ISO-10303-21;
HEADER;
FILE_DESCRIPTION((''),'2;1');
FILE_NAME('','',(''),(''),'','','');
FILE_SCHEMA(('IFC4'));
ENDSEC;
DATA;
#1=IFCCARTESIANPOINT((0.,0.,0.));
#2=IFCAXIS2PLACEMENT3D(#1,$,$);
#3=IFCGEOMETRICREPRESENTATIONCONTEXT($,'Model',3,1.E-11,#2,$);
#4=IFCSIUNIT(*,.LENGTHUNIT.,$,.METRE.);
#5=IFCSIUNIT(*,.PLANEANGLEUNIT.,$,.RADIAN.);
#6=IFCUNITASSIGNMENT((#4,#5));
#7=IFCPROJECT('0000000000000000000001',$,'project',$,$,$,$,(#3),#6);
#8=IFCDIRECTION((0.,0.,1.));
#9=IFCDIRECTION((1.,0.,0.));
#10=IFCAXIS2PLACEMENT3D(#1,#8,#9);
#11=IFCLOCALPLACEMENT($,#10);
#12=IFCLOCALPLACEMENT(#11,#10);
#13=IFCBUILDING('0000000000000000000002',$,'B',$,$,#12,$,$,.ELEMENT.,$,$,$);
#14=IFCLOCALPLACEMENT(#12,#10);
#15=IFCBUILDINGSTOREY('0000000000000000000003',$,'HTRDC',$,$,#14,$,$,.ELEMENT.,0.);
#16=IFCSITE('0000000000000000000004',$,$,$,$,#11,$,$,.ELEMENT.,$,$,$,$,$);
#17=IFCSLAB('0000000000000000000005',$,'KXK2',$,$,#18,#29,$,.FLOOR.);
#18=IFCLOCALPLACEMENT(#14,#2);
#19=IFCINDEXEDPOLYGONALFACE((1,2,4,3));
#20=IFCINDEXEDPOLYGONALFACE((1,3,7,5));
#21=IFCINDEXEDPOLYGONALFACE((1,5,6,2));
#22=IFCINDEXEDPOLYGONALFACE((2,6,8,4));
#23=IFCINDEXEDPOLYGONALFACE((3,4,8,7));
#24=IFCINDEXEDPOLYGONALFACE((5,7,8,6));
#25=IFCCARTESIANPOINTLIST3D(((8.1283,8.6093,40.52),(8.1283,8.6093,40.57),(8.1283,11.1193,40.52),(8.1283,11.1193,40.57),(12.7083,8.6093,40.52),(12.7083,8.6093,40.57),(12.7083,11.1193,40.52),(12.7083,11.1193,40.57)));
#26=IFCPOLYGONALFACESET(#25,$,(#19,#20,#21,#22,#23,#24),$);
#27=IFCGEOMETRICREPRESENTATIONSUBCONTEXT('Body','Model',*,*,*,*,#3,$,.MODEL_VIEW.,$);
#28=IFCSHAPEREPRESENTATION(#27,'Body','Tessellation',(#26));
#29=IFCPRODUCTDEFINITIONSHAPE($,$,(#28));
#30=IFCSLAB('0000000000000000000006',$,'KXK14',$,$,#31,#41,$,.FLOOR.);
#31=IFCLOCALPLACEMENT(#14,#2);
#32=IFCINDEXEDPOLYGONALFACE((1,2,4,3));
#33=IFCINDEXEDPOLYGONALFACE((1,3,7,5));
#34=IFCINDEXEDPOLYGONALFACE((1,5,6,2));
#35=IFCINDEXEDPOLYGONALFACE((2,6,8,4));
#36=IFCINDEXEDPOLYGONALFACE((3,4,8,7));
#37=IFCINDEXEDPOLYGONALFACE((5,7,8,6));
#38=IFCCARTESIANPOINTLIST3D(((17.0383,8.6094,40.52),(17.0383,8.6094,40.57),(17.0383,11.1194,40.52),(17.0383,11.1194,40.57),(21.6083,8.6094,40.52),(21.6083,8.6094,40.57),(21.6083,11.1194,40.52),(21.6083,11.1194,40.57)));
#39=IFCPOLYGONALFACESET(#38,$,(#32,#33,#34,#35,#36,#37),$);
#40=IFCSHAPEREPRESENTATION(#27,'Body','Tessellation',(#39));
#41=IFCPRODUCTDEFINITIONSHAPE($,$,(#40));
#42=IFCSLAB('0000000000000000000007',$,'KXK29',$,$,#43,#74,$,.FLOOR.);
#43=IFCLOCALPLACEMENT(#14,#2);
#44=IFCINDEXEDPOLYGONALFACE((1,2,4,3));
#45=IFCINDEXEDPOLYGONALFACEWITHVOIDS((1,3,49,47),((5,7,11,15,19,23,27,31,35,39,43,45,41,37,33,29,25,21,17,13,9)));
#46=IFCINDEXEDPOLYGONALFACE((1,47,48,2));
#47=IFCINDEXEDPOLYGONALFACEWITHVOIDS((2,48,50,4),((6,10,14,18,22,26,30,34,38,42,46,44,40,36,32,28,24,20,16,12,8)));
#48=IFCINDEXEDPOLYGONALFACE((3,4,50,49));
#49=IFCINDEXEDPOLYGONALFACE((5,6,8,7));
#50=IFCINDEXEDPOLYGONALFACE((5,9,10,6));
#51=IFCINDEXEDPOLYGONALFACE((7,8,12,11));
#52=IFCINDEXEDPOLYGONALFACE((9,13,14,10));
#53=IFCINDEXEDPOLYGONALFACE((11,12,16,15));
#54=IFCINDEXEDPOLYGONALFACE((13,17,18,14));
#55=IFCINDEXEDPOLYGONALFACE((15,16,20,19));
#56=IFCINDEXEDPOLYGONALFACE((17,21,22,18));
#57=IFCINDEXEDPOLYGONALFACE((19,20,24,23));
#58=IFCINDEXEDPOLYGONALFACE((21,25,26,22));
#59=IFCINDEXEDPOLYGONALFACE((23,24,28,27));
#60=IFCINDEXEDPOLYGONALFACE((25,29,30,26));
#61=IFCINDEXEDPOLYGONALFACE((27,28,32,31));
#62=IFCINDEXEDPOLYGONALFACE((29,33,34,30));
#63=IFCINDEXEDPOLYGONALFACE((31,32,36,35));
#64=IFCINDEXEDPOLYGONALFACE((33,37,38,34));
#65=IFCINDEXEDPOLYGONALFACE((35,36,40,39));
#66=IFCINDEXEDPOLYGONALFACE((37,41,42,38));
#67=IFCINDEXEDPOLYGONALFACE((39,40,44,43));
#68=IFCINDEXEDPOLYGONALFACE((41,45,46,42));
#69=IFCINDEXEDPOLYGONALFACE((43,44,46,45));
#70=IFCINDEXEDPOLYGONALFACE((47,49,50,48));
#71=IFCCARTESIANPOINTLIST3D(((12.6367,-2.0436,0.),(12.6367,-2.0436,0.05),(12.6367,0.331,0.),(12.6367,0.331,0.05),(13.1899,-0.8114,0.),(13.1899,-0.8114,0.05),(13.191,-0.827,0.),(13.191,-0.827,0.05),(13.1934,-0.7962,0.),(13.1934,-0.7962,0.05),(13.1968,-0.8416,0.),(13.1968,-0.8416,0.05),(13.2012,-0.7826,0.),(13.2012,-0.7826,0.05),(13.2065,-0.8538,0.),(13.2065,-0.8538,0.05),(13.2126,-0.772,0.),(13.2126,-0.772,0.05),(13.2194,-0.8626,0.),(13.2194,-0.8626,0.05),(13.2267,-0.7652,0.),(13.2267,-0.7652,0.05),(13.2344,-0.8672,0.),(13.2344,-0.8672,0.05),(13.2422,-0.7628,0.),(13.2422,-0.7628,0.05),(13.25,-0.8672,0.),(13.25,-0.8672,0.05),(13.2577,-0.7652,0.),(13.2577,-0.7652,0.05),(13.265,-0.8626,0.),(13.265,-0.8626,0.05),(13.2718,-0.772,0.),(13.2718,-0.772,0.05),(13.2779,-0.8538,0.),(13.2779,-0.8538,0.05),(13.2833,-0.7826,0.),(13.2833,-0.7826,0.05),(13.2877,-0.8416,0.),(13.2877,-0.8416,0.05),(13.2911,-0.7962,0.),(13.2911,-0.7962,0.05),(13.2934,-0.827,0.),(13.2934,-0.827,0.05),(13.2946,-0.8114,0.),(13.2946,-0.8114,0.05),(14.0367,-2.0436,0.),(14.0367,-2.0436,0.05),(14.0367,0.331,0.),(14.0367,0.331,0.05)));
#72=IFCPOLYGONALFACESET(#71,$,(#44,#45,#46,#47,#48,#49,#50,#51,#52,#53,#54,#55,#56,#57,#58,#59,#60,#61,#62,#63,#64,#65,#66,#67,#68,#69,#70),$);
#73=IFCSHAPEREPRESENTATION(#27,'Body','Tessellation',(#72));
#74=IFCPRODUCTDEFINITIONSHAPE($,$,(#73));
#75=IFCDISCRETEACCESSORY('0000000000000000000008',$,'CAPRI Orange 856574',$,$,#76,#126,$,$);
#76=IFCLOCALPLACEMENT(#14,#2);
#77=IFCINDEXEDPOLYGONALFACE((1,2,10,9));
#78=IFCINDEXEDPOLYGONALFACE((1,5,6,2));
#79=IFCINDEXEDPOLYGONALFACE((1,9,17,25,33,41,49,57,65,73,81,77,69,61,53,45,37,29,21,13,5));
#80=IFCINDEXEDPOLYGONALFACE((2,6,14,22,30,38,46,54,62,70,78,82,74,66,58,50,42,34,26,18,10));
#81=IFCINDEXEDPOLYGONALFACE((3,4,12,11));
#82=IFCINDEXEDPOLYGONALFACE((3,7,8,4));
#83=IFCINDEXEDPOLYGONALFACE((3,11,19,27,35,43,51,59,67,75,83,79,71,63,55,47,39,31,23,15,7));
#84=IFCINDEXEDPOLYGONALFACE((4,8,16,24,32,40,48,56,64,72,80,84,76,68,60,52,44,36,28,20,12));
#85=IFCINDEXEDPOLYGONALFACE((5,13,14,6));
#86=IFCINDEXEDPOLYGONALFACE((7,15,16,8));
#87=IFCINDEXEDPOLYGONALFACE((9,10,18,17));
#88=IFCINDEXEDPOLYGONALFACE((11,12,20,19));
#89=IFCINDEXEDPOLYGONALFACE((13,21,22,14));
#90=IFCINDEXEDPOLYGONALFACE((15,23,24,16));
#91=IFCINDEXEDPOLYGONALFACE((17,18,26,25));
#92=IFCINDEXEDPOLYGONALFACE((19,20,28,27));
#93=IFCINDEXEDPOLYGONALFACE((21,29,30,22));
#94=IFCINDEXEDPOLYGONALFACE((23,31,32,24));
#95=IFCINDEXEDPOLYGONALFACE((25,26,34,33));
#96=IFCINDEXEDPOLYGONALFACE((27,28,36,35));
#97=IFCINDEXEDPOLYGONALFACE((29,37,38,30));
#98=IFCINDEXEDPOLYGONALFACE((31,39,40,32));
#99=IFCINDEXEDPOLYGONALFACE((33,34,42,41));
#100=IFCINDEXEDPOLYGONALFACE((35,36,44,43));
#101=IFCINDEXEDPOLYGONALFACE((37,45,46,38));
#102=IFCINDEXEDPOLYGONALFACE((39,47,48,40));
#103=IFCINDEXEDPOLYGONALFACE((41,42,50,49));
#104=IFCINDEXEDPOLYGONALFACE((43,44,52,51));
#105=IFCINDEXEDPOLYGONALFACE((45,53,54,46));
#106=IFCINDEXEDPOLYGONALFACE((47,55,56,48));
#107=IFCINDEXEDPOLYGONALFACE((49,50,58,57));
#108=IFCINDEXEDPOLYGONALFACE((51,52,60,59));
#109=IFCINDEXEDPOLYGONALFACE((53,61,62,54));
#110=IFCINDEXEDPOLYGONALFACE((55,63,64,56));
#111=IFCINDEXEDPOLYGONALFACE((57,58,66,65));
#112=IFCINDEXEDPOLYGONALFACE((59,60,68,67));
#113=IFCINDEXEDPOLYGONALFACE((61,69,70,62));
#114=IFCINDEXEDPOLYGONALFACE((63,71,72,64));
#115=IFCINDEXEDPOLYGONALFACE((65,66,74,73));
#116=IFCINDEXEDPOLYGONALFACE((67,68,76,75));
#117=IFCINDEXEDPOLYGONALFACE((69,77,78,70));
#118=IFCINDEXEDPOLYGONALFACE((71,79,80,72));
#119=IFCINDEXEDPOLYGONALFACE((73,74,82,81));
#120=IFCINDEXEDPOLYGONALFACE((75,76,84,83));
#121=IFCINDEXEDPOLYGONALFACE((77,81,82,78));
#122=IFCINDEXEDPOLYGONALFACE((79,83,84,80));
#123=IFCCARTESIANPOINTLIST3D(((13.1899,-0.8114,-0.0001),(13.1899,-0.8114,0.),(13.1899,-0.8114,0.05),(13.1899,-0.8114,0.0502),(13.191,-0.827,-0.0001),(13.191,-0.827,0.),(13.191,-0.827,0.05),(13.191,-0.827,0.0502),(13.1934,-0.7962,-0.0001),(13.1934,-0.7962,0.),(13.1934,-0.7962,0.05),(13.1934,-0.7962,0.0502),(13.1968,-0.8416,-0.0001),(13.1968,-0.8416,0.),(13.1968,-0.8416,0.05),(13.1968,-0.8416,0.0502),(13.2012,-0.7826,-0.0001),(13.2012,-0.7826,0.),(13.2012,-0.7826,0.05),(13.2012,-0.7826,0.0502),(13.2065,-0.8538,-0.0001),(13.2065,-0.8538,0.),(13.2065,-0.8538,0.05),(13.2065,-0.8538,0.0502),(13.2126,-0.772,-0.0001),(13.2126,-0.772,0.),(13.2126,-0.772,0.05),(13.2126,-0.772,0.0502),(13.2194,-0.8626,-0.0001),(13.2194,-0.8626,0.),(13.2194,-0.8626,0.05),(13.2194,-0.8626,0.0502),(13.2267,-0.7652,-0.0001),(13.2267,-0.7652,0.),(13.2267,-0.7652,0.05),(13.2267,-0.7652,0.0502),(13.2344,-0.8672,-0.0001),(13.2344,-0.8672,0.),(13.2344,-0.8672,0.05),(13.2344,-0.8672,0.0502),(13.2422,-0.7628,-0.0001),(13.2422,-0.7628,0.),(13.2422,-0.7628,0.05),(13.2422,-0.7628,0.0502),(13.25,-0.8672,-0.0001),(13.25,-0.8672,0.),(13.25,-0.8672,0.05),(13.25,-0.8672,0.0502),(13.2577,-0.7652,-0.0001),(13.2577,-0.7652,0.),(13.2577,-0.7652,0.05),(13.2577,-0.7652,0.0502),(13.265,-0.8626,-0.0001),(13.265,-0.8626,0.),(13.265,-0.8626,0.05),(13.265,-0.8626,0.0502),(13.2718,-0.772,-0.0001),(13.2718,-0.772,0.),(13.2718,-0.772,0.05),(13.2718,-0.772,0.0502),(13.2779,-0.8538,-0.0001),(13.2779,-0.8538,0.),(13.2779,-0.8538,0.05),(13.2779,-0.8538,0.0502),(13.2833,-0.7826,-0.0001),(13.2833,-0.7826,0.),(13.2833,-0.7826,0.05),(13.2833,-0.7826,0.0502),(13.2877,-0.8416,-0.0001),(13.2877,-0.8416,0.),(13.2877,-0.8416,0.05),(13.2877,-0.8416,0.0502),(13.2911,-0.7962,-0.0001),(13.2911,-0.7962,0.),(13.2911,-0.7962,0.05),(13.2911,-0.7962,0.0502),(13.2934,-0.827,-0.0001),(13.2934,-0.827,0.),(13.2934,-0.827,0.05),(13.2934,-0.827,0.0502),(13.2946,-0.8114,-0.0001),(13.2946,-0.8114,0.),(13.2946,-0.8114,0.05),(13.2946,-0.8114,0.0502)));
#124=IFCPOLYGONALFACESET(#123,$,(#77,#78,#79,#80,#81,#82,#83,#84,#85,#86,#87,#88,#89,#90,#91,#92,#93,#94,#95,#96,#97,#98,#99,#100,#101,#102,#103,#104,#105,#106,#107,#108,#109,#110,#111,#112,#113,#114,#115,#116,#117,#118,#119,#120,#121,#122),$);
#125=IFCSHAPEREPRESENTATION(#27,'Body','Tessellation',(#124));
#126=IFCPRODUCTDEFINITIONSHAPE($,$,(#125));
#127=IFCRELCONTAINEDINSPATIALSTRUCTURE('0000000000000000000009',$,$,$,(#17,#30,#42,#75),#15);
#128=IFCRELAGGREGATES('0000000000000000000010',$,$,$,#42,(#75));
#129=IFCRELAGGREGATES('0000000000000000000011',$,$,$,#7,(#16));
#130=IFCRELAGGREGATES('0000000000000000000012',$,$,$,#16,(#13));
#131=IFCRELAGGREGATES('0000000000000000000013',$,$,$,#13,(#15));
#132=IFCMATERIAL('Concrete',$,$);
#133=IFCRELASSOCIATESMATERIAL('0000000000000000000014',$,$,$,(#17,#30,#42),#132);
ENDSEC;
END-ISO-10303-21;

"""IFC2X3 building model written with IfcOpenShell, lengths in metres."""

from ifc_helpers import new_model, si_unit, frame, frame_2d, origin, origin_with_axes, origin_2d_with_axis, place, context, subcontext, project, spatial, polyline, circle, outline, extrude, material, element, aggregate, save


model = new_model("IFC2X3")

# Units and contexts
model_context = context("Model", 3, precision=1e-11, world=origin())
body_context = subcontext(model_context, "Body", "Model", "MODEL_VIEW")
ifc_project = project(units=[si_unit("LENGTHUNIT", "METRE"), si_unit("PLANEANGLEUNIT", "RADIAN")], contexts=[model_context])

# Site, building, storey
site_placement = place(None, origin_with_axes())
site = spatial("IfcSite", under=ifc_project, at=site_placement, CompositionType="ELEMENT")
building_placement = place(site_placement, origin_with_axes())
building = spatial("IfcBuilding", under=site, at=building_placement, Name="B", CompositionType="ELEMENT")
storey_placement = place(building_placement, origin_with_axes())
storey = spatial("IfcBuildingStorey", under=building, at=storey_placement, Name="HTRDC", CompositionType="ELEMENT", Elevation=0.0)

# Shared definitions
ifc_material = material(Name="Concrete")

# Slab
slab_1_placement = place(storey_placement, frame((8.1283, 8.6093, 40.52), z_axis=(0.0, 0.0, 1.0), x_axis=(1.0, 0.0, 0.0)))
element("IfcSlab", 1, at=slab_1_placement, inside=storey, material=ifc_material, Name="KXK2", PredefinedType="FLOOR", context=body_context, shape_type="SweptSolid", body=[
    extrude(outline(polyline([(0.0, 0.0), (0.0, -4.58), (2.51, -4.58), (2.51, 0.0), (0.0, 0.0)])), frame((0.0, 0.0, 0.0), z_axis=(0.0, 0.0, 1.0), x_axis=(0.0, 1.0, 0.0)), (0.0, 0.0, 1.0), 0.05),
])

# Slab
slab_2_placement = place(storey_placement, frame((17.0383, 8.6094, 40.52), z_axis=(0.0, 0.0, 1.0), x_axis=(1.0, 0.0, 0.0)))
element("IfcSlab", 2, at=slab_2_placement, inside=storey, material=ifc_material, Name="KXK14", PredefinedType="FLOOR", context=body_context, shape_type="SweptSolid", body=[
    extrude(outline(polyline([(0.0, 0.0), (0.0, -4.57), (2.51, -4.57), (2.51, 0.0), (0.0, 0.0)])), frame((0.0, 0.0, 0.0), z_axis=(0.0, 0.0, 1.0), x_axis=(0.0, 1.0, 0.0)), (0.0, 0.0, 1.0), 0.05),
])

# Slab, opening
slab_3_placement = place(storey_placement, frame((12.6367, -2.0436, 0.0), z_axis=(0.0, 0.0, 1.0), x_axis=(1.0, 0.0, 0.0)))
slab_3 = element("IfcSlab", 3, at=slab_3_placement, inside=storey, material=ifc_material, Name="KXK29", PredefinedType="FLOOR", context=body_context, shape_type="SweptSolid", body=[
    extrude(outline(polyline([(0.0, 0.0), (0.0, -1.4), (2.3746, -1.4), (2.3746, 0.0), (0.0, 0.0)])), frame((0.0, 0.0, 0.0), z_axis=(0.0, 0.0, 1.0), x_axis=(0.0, 1.0, 0.0)), (0.0, 0.0, 1.0), 0.05),
])
opening_1_placement = place(slab_3_placement, frame((0.6056, 1.2282, 0.0), z_axis=(0.0, 0.0, 1.0), x_axis=(1.0, 0.0, 0.0)))
element("IfcOpeningElement", 4, at=opening_1_placement, cuts=slab_3, ObjectType="Opening", context=body_context, shape_type="SweptSolid", body=[
    extrude(circle(Radius=0.0525, at=origin_2d_with_axis()), frame((0.0, 0.0, 0.0), z_axis=(0.0, 0.0, 1.0), x_axis=(0.0, 1.0, 0.0)), (0.0, 0.0, 1.0), 0.05),
])

# Discrete accessory
discrete_accessory_1_placement = place(storey_placement, frame((12.6367, -2.0436, -0.0001), z_axis=(0.0, 0.0, 1.0), x_axis=(1.0, 0.0, 0.0)))
discrete_accessory_1 = element("IfcDiscreteAccessory", 5, at=discrete_accessory_1_placement, inside=storey, Name="CAPRI Orange 856574", context=body_context, shape_type="SweptSolid", body=[
    extrude(circle(Radius=0.0525, at=frame_2d((1.2282, -0.6056), x_axis=(1.0, 0.0))), frame((0.0, 0.0, 0.0), z_axis=(0.0, 0.0, 1.0), x_axis=(0.0, 1.0, 0.0)), (0.0, 0.0, 1.0), 0.0503),
])
aggregate(slab_3, [discrete_accessory_1])

save(model, "model.ifc")
